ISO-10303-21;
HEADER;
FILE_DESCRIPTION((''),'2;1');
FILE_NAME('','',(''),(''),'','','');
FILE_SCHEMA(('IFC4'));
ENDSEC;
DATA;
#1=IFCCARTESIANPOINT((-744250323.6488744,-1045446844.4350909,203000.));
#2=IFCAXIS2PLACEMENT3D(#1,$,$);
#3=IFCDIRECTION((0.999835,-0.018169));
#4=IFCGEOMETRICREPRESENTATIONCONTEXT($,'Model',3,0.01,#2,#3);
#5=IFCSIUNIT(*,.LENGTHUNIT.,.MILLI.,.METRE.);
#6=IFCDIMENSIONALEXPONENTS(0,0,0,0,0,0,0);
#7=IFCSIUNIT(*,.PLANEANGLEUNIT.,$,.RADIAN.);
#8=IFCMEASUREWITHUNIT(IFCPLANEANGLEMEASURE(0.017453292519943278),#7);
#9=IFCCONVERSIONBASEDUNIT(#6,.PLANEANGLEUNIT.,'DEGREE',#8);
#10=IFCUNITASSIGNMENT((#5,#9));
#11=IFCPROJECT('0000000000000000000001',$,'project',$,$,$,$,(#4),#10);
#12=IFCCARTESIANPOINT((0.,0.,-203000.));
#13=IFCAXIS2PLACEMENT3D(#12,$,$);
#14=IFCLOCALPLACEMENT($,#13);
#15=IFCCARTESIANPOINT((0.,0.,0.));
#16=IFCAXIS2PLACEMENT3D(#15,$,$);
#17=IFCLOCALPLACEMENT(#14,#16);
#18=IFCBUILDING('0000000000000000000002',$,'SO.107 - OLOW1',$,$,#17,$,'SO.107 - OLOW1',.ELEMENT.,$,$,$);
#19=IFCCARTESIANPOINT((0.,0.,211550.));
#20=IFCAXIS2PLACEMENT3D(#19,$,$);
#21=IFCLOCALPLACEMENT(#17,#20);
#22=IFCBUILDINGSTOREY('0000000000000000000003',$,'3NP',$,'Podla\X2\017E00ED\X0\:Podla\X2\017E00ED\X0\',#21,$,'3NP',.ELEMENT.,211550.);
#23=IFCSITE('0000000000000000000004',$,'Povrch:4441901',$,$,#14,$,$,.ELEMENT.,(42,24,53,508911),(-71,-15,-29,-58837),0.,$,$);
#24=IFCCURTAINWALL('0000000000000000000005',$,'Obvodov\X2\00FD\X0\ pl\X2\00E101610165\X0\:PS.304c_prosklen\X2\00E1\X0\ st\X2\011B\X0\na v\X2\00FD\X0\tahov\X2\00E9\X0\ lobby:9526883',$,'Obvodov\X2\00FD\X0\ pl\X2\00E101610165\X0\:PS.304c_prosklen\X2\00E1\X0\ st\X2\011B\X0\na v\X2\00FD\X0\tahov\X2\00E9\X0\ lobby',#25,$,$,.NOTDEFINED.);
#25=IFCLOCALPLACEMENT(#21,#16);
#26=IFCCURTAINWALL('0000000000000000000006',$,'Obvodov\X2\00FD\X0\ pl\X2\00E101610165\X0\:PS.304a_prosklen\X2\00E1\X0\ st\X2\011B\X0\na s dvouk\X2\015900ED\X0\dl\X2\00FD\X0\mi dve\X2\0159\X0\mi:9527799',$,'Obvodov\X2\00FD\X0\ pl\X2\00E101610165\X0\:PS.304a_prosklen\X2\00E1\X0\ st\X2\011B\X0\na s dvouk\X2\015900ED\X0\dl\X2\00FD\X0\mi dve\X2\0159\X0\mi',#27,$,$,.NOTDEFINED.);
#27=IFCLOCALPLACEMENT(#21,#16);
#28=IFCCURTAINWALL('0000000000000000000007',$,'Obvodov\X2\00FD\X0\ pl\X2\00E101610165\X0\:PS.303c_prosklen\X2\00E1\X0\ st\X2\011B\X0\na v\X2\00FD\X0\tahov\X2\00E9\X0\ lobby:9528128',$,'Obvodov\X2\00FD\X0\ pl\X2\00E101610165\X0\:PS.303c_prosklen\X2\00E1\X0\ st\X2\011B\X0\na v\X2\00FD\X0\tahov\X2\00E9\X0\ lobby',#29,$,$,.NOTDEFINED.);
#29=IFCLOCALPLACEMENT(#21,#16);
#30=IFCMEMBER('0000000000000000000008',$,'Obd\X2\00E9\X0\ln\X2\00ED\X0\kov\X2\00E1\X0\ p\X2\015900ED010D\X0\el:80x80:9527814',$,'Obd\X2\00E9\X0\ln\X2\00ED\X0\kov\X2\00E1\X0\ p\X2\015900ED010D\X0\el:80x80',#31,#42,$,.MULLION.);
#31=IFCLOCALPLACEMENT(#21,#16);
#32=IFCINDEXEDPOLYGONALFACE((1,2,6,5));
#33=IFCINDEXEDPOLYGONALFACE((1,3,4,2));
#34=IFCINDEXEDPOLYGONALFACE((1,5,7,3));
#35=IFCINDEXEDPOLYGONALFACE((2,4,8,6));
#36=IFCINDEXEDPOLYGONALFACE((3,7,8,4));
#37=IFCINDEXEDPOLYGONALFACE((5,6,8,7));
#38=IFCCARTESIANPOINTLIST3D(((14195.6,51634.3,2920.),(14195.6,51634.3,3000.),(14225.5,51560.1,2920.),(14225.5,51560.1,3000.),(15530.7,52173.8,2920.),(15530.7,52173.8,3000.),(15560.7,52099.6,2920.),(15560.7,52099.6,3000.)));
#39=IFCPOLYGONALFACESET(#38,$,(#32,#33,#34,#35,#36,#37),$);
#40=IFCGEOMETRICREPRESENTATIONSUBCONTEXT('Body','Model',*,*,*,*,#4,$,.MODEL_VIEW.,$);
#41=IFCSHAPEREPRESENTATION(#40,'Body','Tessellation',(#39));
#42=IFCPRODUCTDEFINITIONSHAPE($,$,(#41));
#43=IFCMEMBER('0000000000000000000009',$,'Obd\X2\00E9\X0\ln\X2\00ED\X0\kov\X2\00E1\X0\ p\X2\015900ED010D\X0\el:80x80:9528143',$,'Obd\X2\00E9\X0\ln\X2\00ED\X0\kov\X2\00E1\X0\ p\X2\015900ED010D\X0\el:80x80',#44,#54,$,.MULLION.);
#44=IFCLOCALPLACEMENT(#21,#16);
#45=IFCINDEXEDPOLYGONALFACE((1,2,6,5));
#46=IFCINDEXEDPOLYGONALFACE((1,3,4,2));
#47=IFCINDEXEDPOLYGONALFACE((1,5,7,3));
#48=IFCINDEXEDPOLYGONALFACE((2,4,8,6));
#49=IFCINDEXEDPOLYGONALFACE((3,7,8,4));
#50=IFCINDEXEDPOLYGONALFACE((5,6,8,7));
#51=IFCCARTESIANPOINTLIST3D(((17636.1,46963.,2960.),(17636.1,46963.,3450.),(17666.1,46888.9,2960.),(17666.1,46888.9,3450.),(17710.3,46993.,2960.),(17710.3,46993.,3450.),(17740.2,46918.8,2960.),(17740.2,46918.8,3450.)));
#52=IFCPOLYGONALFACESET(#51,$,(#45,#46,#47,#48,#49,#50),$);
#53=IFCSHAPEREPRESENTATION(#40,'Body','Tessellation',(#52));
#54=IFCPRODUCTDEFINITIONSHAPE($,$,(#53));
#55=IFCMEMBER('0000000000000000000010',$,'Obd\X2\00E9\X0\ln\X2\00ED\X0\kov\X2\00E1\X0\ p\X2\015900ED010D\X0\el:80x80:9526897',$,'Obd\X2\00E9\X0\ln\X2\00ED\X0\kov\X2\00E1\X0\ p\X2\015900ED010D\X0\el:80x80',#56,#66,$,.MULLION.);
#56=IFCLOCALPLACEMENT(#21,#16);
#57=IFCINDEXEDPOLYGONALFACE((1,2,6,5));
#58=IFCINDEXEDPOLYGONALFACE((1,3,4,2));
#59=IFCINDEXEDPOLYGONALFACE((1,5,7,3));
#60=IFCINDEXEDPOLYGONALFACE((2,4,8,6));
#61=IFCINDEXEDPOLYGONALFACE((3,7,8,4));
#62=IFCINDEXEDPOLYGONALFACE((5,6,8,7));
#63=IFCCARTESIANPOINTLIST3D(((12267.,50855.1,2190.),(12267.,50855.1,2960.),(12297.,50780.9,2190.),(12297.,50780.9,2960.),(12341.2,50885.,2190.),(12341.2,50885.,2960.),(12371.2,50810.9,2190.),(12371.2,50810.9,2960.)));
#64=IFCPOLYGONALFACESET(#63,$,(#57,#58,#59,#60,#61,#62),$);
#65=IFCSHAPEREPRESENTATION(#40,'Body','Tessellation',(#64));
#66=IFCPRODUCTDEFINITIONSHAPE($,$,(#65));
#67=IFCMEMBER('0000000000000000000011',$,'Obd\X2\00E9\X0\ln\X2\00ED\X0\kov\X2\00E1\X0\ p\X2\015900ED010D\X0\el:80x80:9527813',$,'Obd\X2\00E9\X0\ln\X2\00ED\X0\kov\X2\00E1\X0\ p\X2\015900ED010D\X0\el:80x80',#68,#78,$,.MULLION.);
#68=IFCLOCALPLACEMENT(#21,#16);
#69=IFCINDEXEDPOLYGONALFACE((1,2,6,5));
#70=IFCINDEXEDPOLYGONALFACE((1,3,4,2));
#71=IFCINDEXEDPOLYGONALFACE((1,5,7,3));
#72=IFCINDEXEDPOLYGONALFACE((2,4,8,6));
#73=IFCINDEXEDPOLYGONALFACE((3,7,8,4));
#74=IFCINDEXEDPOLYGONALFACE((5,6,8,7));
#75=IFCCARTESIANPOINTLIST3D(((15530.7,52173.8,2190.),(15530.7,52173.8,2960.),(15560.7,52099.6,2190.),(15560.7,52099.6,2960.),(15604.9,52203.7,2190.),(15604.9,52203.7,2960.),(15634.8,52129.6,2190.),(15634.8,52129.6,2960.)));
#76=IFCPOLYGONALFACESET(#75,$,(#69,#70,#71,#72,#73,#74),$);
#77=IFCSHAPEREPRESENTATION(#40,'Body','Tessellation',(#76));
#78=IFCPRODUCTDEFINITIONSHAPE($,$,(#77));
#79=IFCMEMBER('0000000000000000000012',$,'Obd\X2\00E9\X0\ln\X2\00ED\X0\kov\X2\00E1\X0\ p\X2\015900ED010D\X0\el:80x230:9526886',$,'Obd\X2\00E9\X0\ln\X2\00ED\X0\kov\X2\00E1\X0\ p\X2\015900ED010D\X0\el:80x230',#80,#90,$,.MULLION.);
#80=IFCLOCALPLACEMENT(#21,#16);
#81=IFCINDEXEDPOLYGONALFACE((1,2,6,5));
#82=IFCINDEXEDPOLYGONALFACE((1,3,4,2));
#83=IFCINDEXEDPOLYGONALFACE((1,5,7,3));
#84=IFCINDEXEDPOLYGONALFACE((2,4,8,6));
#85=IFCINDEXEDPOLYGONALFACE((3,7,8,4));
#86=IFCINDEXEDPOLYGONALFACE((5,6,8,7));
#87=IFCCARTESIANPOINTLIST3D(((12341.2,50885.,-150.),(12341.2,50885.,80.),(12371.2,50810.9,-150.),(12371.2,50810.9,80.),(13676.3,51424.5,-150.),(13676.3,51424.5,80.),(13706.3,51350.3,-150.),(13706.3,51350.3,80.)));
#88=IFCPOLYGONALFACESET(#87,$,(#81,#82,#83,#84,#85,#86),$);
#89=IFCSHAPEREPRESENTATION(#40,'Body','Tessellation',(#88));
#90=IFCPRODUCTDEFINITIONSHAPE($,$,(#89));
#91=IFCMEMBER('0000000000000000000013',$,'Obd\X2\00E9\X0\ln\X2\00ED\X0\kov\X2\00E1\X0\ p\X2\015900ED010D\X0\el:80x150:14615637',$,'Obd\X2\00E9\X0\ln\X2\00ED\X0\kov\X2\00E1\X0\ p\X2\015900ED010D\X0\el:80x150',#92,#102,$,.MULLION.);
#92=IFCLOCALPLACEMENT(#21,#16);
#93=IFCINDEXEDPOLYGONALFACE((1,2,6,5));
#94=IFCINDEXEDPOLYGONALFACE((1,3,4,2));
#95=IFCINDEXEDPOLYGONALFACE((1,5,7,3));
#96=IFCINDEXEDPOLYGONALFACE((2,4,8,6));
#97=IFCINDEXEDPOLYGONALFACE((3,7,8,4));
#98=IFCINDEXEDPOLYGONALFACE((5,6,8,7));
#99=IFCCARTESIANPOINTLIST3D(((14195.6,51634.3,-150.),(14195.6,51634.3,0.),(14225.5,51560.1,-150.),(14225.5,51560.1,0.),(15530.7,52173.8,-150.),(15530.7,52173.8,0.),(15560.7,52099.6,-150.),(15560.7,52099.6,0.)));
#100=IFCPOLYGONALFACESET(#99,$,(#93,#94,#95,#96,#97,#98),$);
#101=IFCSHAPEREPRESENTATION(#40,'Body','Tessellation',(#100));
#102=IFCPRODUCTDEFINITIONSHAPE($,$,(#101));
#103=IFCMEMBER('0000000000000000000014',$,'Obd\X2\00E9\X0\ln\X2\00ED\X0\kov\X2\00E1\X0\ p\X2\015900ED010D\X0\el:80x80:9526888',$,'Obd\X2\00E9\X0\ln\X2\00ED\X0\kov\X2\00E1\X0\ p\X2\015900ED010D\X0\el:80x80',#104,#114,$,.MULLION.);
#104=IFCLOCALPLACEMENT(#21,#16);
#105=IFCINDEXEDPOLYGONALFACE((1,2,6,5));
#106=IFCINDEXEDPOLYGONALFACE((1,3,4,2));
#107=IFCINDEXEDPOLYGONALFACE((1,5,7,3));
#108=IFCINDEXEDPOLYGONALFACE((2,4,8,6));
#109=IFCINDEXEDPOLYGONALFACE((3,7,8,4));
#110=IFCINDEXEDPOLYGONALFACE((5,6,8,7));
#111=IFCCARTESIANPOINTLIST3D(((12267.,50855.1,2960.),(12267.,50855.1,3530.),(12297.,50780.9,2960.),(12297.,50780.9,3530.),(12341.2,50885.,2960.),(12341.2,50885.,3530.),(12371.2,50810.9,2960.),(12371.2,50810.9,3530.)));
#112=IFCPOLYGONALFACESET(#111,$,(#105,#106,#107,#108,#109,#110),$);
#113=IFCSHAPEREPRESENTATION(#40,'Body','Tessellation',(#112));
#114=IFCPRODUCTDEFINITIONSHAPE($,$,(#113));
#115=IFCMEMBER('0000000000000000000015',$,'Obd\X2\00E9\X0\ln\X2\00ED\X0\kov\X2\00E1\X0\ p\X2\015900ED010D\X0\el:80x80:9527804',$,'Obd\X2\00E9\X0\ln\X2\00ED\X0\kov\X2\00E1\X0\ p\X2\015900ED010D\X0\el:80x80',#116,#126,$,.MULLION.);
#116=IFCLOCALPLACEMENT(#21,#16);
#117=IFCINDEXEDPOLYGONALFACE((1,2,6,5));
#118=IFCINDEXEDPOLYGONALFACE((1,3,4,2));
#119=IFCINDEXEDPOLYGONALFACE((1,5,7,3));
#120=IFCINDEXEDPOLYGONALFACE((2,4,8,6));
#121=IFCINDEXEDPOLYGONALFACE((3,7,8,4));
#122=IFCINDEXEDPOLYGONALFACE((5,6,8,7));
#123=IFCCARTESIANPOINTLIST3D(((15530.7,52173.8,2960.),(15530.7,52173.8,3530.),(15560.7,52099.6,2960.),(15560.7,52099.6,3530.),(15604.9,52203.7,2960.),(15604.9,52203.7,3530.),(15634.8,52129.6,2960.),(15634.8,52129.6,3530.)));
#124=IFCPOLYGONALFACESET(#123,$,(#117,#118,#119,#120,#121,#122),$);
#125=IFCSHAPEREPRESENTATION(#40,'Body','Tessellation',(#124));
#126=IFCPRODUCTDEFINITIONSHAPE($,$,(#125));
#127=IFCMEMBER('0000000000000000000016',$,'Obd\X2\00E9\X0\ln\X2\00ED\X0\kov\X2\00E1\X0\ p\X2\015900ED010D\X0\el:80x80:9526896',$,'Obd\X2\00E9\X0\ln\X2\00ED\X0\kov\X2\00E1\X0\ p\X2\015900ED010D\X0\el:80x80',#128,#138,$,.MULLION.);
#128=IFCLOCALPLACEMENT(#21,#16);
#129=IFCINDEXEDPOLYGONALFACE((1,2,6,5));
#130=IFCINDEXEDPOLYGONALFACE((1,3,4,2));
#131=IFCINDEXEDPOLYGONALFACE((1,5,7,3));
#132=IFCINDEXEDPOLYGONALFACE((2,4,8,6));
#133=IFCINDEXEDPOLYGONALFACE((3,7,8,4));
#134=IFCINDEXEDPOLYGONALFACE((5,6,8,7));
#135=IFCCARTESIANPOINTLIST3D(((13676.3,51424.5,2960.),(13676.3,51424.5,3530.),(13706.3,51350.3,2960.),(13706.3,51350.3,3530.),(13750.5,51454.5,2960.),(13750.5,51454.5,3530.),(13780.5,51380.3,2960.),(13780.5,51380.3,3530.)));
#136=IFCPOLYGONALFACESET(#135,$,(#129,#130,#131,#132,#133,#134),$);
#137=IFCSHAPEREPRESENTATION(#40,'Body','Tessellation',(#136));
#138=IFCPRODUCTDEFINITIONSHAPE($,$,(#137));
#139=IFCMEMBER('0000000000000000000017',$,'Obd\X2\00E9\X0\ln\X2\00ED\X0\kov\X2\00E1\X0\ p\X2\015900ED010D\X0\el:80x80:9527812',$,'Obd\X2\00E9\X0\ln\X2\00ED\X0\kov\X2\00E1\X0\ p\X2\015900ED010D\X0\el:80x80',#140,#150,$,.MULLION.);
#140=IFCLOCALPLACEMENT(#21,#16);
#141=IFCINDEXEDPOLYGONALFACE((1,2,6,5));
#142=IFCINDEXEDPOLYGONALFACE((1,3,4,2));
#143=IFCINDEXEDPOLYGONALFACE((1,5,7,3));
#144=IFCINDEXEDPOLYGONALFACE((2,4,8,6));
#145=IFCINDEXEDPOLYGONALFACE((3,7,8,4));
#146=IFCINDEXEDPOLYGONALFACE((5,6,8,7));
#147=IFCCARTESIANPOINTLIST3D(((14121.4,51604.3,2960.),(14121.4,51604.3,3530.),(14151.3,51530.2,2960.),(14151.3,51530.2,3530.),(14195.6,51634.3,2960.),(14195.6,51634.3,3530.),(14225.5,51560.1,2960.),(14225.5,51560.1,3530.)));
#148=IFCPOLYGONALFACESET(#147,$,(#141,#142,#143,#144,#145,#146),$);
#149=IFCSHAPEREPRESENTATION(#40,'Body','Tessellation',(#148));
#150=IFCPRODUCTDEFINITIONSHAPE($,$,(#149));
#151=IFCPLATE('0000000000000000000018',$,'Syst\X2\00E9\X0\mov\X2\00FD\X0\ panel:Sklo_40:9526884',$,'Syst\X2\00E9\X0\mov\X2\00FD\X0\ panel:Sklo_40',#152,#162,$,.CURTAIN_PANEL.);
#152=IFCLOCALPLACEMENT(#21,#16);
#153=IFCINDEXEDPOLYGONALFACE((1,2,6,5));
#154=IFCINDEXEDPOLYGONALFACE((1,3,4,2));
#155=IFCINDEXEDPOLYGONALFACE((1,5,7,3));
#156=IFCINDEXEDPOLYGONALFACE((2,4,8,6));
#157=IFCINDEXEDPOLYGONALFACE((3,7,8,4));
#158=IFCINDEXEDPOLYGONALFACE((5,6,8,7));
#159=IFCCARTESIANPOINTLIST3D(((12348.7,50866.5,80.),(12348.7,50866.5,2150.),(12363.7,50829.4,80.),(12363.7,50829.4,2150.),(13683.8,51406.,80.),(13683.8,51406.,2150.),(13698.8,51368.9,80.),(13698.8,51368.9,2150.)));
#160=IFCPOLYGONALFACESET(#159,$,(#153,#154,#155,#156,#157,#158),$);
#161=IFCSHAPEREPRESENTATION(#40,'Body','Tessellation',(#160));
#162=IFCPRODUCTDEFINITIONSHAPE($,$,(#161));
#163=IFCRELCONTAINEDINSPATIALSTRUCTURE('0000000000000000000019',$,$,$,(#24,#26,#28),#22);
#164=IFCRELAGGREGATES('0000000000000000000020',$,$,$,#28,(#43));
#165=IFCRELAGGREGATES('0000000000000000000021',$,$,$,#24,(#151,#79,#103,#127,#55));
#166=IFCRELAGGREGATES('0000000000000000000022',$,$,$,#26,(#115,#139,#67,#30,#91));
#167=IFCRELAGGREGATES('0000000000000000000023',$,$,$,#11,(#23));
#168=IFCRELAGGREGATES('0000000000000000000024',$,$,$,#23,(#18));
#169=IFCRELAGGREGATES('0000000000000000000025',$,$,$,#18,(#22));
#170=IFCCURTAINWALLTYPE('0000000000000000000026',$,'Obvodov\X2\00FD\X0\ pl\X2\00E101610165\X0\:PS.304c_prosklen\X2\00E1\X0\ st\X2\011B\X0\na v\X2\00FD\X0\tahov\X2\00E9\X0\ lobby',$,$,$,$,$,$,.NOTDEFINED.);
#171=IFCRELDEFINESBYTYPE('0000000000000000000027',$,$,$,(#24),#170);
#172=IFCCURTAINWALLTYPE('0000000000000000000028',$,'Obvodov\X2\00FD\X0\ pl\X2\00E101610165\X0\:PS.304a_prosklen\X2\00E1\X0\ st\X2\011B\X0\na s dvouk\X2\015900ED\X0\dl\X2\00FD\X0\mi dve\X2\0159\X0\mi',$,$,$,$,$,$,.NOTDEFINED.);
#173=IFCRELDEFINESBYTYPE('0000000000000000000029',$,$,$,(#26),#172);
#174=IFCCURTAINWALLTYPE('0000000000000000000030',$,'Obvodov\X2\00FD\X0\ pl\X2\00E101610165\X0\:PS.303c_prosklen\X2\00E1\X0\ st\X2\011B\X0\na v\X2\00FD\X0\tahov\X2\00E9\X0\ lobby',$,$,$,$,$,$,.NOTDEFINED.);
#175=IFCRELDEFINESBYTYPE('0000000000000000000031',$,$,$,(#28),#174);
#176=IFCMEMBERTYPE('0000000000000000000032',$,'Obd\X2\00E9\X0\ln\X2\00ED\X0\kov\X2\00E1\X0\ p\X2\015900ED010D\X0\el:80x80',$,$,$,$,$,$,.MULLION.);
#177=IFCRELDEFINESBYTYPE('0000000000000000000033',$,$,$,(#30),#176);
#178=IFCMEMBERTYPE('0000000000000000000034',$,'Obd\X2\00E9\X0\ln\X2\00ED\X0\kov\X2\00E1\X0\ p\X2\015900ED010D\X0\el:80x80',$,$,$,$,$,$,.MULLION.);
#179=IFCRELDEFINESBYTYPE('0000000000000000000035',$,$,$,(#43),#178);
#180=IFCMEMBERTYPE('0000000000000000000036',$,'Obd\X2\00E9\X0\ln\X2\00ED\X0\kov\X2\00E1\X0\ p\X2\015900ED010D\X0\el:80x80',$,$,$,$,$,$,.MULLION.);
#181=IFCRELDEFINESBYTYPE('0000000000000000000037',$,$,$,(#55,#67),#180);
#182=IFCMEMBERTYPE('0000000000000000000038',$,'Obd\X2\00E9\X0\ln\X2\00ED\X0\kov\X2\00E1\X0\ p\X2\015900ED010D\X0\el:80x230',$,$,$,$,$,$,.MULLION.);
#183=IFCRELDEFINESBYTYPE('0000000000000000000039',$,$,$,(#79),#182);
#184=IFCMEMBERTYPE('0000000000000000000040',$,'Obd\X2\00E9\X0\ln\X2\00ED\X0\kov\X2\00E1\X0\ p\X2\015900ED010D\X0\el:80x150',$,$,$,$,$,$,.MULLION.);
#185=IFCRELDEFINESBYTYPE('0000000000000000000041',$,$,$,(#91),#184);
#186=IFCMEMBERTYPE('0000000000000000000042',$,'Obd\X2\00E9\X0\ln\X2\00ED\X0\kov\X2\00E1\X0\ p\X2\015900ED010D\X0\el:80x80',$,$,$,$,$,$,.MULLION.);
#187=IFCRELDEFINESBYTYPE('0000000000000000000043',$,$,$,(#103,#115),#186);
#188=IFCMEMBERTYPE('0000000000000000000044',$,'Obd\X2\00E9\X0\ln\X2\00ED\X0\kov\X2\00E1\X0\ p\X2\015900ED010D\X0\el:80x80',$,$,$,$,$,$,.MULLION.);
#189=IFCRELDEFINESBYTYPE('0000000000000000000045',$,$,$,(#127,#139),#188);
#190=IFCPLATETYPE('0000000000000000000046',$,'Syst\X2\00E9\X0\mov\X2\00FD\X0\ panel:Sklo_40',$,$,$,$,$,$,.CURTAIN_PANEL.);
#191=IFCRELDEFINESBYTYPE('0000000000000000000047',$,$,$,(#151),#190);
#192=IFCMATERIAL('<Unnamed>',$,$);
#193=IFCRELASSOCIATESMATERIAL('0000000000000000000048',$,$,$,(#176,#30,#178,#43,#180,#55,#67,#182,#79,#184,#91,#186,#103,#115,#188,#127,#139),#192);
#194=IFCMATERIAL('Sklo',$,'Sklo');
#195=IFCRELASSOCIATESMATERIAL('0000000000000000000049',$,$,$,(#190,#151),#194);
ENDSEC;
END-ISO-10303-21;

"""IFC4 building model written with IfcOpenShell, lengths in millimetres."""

from ifc_helpers import new_model, entity, si_unit, converted_unit, direction, frame, origin, place, context, subcontext, project, spatial, indexed_curve, outline, extrude, source, transform, mapped, material, type_object, type_shapes, element, aggregate, save


model = new_model("IFC4")

# Units and contexts
model_context = context("Model", 3, precision=0.01, world=frame((-744250323.6488744, -1045446844.4350909, 203000.0)), true_north=direction((0.999835, -0.018169)))
body_context = subcontext(model_context, "Body", "Model", "MODEL_VIEW")
ifc_project = project(units=[si_unit("LENGTHUNIT", "METRE", prefix="MILLI"), converted_unit("PLANEANGLEUNIT", "DEGREE", entity("IfcPlaneAngleMeasure", 0.017453292519943278), si_unit("PLANEANGLEUNIT", "RADIAN"), dimensions=[0, 0, 0, 0, 0, 0, 0])], contexts=[model_context])

# Site, building, storey
site_placement = place(None, frame((0.0, 0.0, -203000.0)))
site = spatial("IfcSite", under=ifc_project, at=site_placement, Name="Povrch:4441901", CompositionType="ELEMENT", RefLatitude=(42, 24, 53, 508911), RefLongitude=(-71, -15, -29, -58837), RefElevation=0.0)
building_placement = place(site_placement, origin())
building = spatial("IfcBuilding", under=site, at=building_placement, Name="SO.107 - OLOW1", LongName="SO.107 - OLOW1", CompositionType="ELEMENT")
storey_placement = place(building_placement, frame((0.0, 0.0, 211550.0)))
storey = spatial("IfcBuildingStorey", under=building, at=storey_placement, Name="3NP", ObjectType="Podlaží:Podlaží", LongName="3NP", CompositionType="ELEMENT", Elevation=211550.0)

# Curtain walls
curtain_wall_type_1 = type_object("IfcCurtainWallType", Name="Obvodový plášť:PS.304c_prosklená stěna výtahové lobby", PredefinedType="NOTDEFINED")
curtain_wall_1_placement = place(storey_placement, frame((0.0, 0.0, -211550.0)))
curtain_wall_1 = element("IfcCurtainWall", 1, at=curtain_wall_1_placement, inside=storey, type_object=curtain_wall_type_1, Name="Obvodový plášť:PS.304c_prosklená stěna výtahové lobby:9526883", ObjectType="Obvodový plášť:PS.304c_prosklená stěna výtahové lobby", PredefinedType="NOTDEFINED")
ifc_material_1 = material(Name="<Unnamed>")
curtain_wall_type_2 = type_object("IfcCurtainWallType", Name="Obvodový plášť:PS.304a_prosklená stěna s dvoukřídlými dveřmi", PredefinedType="NOTDEFINED")
curtain_wall_2_placement = place(storey_placement, frame((0.0, 0.0, -211550.0)))
curtain_wall_2 = element("IfcCurtainWall", 2, at=curtain_wall_2_placement, inside=storey, type_object=curtain_wall_type_2, Name="Obvodový plášť:PS.304a_prosklená stěna s dvoukřídlými dveřmi:9527799", ObjectType="Obvodový plášť:PS.304a_prosklená stěna s dvoukřídlými dveřmi", PredefinedType="NOTDEFINED")

# Curtain wall
curtain_wall_type_3 = type_object("IfcCurtainWallType", Name="Obvodový plášť:PS.303c_prosklená stěna výtahové lobby", PredefinedType="NOTDEFINED")
curtain_wall_3_placement = place(storey_placement, frame((0.0, 0.0, -211550.0)))
curtain_wall_3 = element("IfcCurtainWall", 3, at=curtain_wall_3_placement, inside=storey, type_object=curtain_wall_type_3, Name="Obvodový plášť:PS.303c_prosklená stěna výtahové lobby:9528128", ObjectType="Obvodový plášť:PS.303c_prosklená stěna výtahové lobby", PredefinedType="NOTDEFINED")

# Members
member_type_1 = type_object("IfcMemberType", Name="Obdélníková příčel:80x80", PredefinedType="MULLION", material=ifc_material_1)
shared_shape_1 = source(origin(), body_context, "Body", "SweptSolid", [
    extrude(outline(indexed_curve([(-40.0, -40.0), (40.0, -40.0), (40.0, 40.0), (-40.0, 40.0), (-40.0, -40.0)], self_intersect=False)), frame((0.0, 0.0, -1440.0), z_axis=(0.0, 0.0, 1.0), x_axis=(-1.0, 0.0, 0.0)), (0.0, 0.0, 1.0), 1440.0),
])
type_shapes(member_type_1, [shared_shape_1])
member_1_placement = place(curtain_wall_2_placement, frame((14210.5, 51597.2, 214510.0), z_axis=(-0.927176, -0.374626, 0.0), x_axis=(0.0, 0.0, 1.0)))
member_1 = element("IfcMember", 4, at=member_1_placement, type_object=member_type_1, material=ifc_material_1, Name="Obdélníková příčel:80x80:9527814", ObjectType="Obdélníková příčel:80x80", PredefinedType="MULLION", context=body_context, shape_type="MappedRepresentation", body=[
    mapped(shared_shape_1, transform((0.0, 0.0, 0.0), scale=1.0)),
])
member_type_2 = type_object("IfcMemberType", Name="Obdélníková příčel:80x80", PredefinedType="MULLION", material=ifc_material_1)
shared_shape_2 = source(origin(), body_context, "Body", "SweptSolid", [
    extrude(outline(indexed_curve([(-40.0, -40.0), (40.0, -40.0), (40.0, 40.0), (-40.0, 40.0), (-40.0, -40.0)], self_intersect=False)), frame((-40.0, 0.0, -490.0), z_axis=(0.0, 0.0, 1.0), x_axis=(-1.0, 0.0, 0.0)), (0.0, 0.0, 1.0), 490.0),
])
type_shapes(member_type_2, [shared_shape_2])
member_2_placement = place(curtain_wall_3_placement, frame((17725.2, 46955.9, 214510.0), z_axis=(0.0, 0.0, -1.0), x_axis=(0.927176, 0.374626, 0.0)))
member_2 = element("IfcMember", 5, at=member_2_placement, type_object=member_type_2, material=ifc_material_1, Name="Obdélníková příčel:80x80:9528143", ObjectType="Obdélníková příčel:80x80", PredefinedType="MULLION", context=body_context, shape_type="MappedRepresentation", body=[
    mapped(shared_shape_2, transform((0.0, 0.0, 0.0), scale=1.0)),
])
aggregate(curtain_wall_3, [member_2])
member_type_3 = type_object("IfcMemberType", Name="Obdélníková příčel:80x80", PredefinedType="MULLION", material=ifc_material_1)
shared_shape_3 = source(origin(), body_context, "Body", "SweptSolid", [
    extrude(outline(indexed_curve([(-40.0, -40.0), (40.0, -40.0), (40.0, 40.0), (-40.0, 40.0), (-40.0, -40.0)], self_intersect=False)), frame((-40.0, 0.0, -770.0), z_axis=(0.0, 0.0, 1.0), x_axis=(-1.0, 0.0, 0.0)), (0.0, 0.0, 1.0), 770.0),
])
type_shapes(member_type_3, [shared_shape_3])
member_3_placement = place(curtain_wall_1_placement, frame((12282.0, 50818.0, 214510.0), z_axis=(0.0, 0.0, 1.0), x_axis=(-0.927176, -0.374626, 0.0)))
member_3 = element("IfcMember", 6, at=member_3_placement, type_object=member_type_3, material=ifc_material_1, Name="Obdélníková příčel:80x80:9526897", ObjectType="Obdélníková příčel:80x80", PredefinedType="MULLION", context=body_context, shape_type="MappedRepresentation", body=[
    mapped(shared_shape_3, transform((0.0, 0.0, 0.0), scale=1.0)),
])
member_4_placement = place(curtain_wall_2_placement, frame((15619.8, 52166.6, 214510.0), z_axis=(0.0, 0.0, 1.0), x_axis=(0.927176, 0.374626, 0.0)))
member_4 = element("IfcMember", 7, at=member_4_placement, type_object=member_type_3, material=ifc_material_1, Name="Obdélníková příčel:80x80:9527813", ObjectType="Obdélníková příčel:80x80", PredefinedType="MULLION", context=body_context, shape_type="MappedRepresentation", body=[
    mapped(shared_shape_3, transform((0.0, 0.0, 0.0), scale=1.0)),
])
member_type_4 = type_object("IfcMemberType", Name="Obdélníková příčel:80x230", PredefinedType="MULLION", material=ifc_material_1)
shared_shape_4 = source(origin(), body_context, "Body", "SweptSolid", [
    extrude(outline(indexed_curve([(-115.0, -40.0), (115.0, -40.0), (115.0, 40.0), (-115.0, 40.0), (-115.0, -40.0)], self_intersect=False)), frame((-115.0, 0.0, -1440.0), z_axis=(0.0, 0.0, 1.0), x_axis=(-1.0, 0.0, 0.0)), (0.0, 0.0, 1.0), 1440.0),
])
type_shapes(member_type_4, [shared_shape_4])
member_5_placement = place(curtain_wall_1_placement, frame((12356.2, 50848.0, 211400.0), z_axis=(-0.927176, -0.374626, 0.0), x_axis=(0.0, 0.0, -1.0)))
member_5 = element("IfcMember", 8, at=member_5_placement, type_object=member_type_4, material=ifc_material_1, Name="Obdélníková příčel:80x230:9526886", ObjectType="Obdélníková příčel:80x230", PredefinedType="MULLION", context=body_context, shape_type="MappedRepresentation", body=[
    mapped(shared_shape_4, transform((0.0, 0.0, 0.0), scale=1.0)),
])
member_type_5 = type_object("IfcMemberType", Name="Obdélníková příčel:80x150", PredefinedType="MULLION", material=ifc_material_1)
shared_shape_5 = source(origin(), body_context, "Body", "SweptSolid", [
    extrude(outline(indexed_curve([(-75.0, -40.0), (75.0, -40.0), (75.0, 40.0), (-75.0, 40.0), (-75.0, -40.0)], self_intersect=False)), frame((-75.0, 0.0, -1440.0), z_axis=(0.0, 0.0, 1.0), x_axis=(-1.0, 0.0, 0.0)), (0.0, 0.0, 1.0), 1440.0),
])
type_shapes(member_type_5, [shared_shape_5])
member_6_placement = place(curtain_wall_2_placement, frame((15545.7, 52136.7, 211400.0), z_axis=(0.927176, 0.374626, 0.0), x_axis=(0.0, 0.0, -1.0)))
member_6 = element("IfcMember", 9, at=member_6_placement, type_object=member_type_5, material=ifc_material_1, Name="Obdélníková příčel:80x150:14615637", ObjectType="Obdélníková příčel:80x150", PredefinedType="MULLION", context=body_context, shape_type="MappedRepresentation", body=[
    mapped(shared_shape_5, transform((0.0, 0.0, 0.0), scale=1.0)),
])
member_type_6 = type_object("IfcMemberType", Name="Obdélníková příčel:80x80", PredefinedType="MULLION", material=ifc_material_1)
shared_shape_6 = source(origin(), body_context, "Body", "SweptSolid", [
    extrude(outline(indexed_curve([(-40.0, -40.0), (40.0, -40.0), (40.0, 40.0), (-40.0, 40.0), (-40.0, -40.0)], self_intersect=False)), frame((-40.0, 0.0, -570.0), z_axis=(0.0, 0.0, 1.0), x_axis=(-1.0, 0.0, 0.0)), (0.0, 0.0, 1.0), 570.0),
])
type_shapes(member_type_6, [shared_shape_6])
member_7_placement = place(curtain_wall_1_placement, frame((12282.0, 50818.0, 215080.0), z_axis=(0.0, 0.0, 1.0), x_axis=(-0.927176, -0.374626, 0.0)))
member_7 = element("IfcMember", 10, at=member_7_placement, type_object=member_type_6, material=ifc_material_1, Name="Obdélníková příčel:80x80:9526888", ObjectType="Obdélníková příčel:80x80", PredefinedType="MULLION", context=body_context, shape_type="MappedRepresentation", body=[
    mapped(shared_shape_6, transform((0.0, 0.0, 0.0), scale=1.0)),
])
member_8_placement = place(curtain_wall_2_placement, frame((15619.8, 52166.6, 215080.0), z_axis=(0.0, 0.0, 1.0), x_axis=(0.927176, 0.374626, 0.0)))
member_8 = element("IfcMember", 11, at=member_8_placement, type_object=member_type_6, material=ifc_material_1, Name="Obdélníková příčel:80x80:9527804", ObjectType="Obdélníková příčel:80x80", PredefinedType="MULLION", context=body_context, shape_type="MappedRepresentation", body=[
    mapped(shared_shape_6, transform((0.0, 0.0, 0.0), scale=1.0)),
])
member_type_7 = type_object("IfcMemberType", Name="Obdélníková příčel:80x80", PredefinedType="MULLION", material=ifc_material_1)
shared_shape_7 = source(origin(), body_context, "Body", "SweptSolid", [
    extrude(outline(indexed_curve([(-40.0, -40.0), (40.0, -40.0), (40.0, 40.0), (-40.0, 40.0), (-40.0, -40.0)], self_intersect=False)), frame((-40.0, 0.0, -570.0), z_axis=(0.0, 0.0, 1.0), x_axis=(-1.0, 0.0, 0.0)), (0.0, 0.0, 1.0), 570.0),
])
type_shapes(member_type_7, [shared_shape_7])
member_9_placement = place(curtain_wall_1_placement, frame((13765.5, 51417.4, 214510.0), z_axis=(0.0, 0.0, -1.0), x_axis=(0.927176, 0.374626, 0.0)))
member_9 = element("IfcMember", 12, at=member_9_placement, type_object=member_type_7, material=ifc_material_1, Name="Obdélníková příčel:80x80:9526896", ObjectType="Obdélníková příčel:80x80", PredefinedType="MULLION", context=body_context, shape_type="MappedRepresentation", body=[
    mapped(shared_shape_7, transform((0.0, 0.0, 0.0), scale=1.0)),
])
member_10_placement = place(curtain_wall_2_placement, frame((14136.4, 51567.2, 214510.0), z_axis=(0.0, 0.0, -1.0), x_axis=(-0.927176, -0.374626, 0.0)))
member_10 = element("IfcMember", 13, at=member_10_placement, type_object=member_type_7, material=ifc_material_1, Name="Obdélníková příčel:80x80:9527812", ObjectType="Obdélníková příčel:80x80", PredefinedType="MULLION", context=body_context, shape_type="MappedRepresentation", body=[
    mapped(shared_shape_7, transform((0.0, 0.0, 0.0), scale=1.0)),
])

# Plate
ifc_material_2 = material(Name="Sklo", Category="Sklo")
plate_type_1 = type_object("IfcPlateType", Name="Systémový panel:Sklo_40", PredefinedType="CURTAIN_PANEL", material=ifc_material_2)
shared_shape_8 = source(origin(), body_context, "Body", "SweptSolid", [
    extrude(outline(indexed_curve([(-20.0, -720.0), (20.0, -720.0), (20.0, 720.0), (-20.0, 720.0), (-20.0, -720.0)], self_intersect=False)), frame((0.0, 0.0, 0.0), z_axis=(0.0, 0.0, 1.0), x_axis=(0.0, 1.0, 0.0)), (0.0, 0.0, 1.0), 2070.0),
])
type_shapes(plate_type_1, [shared_shape_8])
plate_1_placement = place(curtain_wall_1_placement, frame((13023.8, 51117.7, 211630.0), z_axis=(0.0, 0.0, 1.0), x_axis=(0.927176, 0.374626, 0.0)))
plate_1 = element("IfcPlate", 14, at=plate_1_placement, type_object=plate_type_1, material=ifc_material_2, Name="Systémový panel:Sklo_40:9526884", ObjectType="Systémový panel:Sklo_40", PredefinedType="CURTAIN_PANEL", context=body_context, shape_type="MappedRepresentation", body=[
    mapped(shared_shape_8, transform((0.0, 0.0, 0.0), scale=1.0)),
])
aggregate(curtain_wall_1, [plate_1, member_5, member_7, member_9, member_3])

aggregate(curtain_wall_2, [member_8, member_10, member_4, member_1, member_6])

save(model, "model.ifc")
